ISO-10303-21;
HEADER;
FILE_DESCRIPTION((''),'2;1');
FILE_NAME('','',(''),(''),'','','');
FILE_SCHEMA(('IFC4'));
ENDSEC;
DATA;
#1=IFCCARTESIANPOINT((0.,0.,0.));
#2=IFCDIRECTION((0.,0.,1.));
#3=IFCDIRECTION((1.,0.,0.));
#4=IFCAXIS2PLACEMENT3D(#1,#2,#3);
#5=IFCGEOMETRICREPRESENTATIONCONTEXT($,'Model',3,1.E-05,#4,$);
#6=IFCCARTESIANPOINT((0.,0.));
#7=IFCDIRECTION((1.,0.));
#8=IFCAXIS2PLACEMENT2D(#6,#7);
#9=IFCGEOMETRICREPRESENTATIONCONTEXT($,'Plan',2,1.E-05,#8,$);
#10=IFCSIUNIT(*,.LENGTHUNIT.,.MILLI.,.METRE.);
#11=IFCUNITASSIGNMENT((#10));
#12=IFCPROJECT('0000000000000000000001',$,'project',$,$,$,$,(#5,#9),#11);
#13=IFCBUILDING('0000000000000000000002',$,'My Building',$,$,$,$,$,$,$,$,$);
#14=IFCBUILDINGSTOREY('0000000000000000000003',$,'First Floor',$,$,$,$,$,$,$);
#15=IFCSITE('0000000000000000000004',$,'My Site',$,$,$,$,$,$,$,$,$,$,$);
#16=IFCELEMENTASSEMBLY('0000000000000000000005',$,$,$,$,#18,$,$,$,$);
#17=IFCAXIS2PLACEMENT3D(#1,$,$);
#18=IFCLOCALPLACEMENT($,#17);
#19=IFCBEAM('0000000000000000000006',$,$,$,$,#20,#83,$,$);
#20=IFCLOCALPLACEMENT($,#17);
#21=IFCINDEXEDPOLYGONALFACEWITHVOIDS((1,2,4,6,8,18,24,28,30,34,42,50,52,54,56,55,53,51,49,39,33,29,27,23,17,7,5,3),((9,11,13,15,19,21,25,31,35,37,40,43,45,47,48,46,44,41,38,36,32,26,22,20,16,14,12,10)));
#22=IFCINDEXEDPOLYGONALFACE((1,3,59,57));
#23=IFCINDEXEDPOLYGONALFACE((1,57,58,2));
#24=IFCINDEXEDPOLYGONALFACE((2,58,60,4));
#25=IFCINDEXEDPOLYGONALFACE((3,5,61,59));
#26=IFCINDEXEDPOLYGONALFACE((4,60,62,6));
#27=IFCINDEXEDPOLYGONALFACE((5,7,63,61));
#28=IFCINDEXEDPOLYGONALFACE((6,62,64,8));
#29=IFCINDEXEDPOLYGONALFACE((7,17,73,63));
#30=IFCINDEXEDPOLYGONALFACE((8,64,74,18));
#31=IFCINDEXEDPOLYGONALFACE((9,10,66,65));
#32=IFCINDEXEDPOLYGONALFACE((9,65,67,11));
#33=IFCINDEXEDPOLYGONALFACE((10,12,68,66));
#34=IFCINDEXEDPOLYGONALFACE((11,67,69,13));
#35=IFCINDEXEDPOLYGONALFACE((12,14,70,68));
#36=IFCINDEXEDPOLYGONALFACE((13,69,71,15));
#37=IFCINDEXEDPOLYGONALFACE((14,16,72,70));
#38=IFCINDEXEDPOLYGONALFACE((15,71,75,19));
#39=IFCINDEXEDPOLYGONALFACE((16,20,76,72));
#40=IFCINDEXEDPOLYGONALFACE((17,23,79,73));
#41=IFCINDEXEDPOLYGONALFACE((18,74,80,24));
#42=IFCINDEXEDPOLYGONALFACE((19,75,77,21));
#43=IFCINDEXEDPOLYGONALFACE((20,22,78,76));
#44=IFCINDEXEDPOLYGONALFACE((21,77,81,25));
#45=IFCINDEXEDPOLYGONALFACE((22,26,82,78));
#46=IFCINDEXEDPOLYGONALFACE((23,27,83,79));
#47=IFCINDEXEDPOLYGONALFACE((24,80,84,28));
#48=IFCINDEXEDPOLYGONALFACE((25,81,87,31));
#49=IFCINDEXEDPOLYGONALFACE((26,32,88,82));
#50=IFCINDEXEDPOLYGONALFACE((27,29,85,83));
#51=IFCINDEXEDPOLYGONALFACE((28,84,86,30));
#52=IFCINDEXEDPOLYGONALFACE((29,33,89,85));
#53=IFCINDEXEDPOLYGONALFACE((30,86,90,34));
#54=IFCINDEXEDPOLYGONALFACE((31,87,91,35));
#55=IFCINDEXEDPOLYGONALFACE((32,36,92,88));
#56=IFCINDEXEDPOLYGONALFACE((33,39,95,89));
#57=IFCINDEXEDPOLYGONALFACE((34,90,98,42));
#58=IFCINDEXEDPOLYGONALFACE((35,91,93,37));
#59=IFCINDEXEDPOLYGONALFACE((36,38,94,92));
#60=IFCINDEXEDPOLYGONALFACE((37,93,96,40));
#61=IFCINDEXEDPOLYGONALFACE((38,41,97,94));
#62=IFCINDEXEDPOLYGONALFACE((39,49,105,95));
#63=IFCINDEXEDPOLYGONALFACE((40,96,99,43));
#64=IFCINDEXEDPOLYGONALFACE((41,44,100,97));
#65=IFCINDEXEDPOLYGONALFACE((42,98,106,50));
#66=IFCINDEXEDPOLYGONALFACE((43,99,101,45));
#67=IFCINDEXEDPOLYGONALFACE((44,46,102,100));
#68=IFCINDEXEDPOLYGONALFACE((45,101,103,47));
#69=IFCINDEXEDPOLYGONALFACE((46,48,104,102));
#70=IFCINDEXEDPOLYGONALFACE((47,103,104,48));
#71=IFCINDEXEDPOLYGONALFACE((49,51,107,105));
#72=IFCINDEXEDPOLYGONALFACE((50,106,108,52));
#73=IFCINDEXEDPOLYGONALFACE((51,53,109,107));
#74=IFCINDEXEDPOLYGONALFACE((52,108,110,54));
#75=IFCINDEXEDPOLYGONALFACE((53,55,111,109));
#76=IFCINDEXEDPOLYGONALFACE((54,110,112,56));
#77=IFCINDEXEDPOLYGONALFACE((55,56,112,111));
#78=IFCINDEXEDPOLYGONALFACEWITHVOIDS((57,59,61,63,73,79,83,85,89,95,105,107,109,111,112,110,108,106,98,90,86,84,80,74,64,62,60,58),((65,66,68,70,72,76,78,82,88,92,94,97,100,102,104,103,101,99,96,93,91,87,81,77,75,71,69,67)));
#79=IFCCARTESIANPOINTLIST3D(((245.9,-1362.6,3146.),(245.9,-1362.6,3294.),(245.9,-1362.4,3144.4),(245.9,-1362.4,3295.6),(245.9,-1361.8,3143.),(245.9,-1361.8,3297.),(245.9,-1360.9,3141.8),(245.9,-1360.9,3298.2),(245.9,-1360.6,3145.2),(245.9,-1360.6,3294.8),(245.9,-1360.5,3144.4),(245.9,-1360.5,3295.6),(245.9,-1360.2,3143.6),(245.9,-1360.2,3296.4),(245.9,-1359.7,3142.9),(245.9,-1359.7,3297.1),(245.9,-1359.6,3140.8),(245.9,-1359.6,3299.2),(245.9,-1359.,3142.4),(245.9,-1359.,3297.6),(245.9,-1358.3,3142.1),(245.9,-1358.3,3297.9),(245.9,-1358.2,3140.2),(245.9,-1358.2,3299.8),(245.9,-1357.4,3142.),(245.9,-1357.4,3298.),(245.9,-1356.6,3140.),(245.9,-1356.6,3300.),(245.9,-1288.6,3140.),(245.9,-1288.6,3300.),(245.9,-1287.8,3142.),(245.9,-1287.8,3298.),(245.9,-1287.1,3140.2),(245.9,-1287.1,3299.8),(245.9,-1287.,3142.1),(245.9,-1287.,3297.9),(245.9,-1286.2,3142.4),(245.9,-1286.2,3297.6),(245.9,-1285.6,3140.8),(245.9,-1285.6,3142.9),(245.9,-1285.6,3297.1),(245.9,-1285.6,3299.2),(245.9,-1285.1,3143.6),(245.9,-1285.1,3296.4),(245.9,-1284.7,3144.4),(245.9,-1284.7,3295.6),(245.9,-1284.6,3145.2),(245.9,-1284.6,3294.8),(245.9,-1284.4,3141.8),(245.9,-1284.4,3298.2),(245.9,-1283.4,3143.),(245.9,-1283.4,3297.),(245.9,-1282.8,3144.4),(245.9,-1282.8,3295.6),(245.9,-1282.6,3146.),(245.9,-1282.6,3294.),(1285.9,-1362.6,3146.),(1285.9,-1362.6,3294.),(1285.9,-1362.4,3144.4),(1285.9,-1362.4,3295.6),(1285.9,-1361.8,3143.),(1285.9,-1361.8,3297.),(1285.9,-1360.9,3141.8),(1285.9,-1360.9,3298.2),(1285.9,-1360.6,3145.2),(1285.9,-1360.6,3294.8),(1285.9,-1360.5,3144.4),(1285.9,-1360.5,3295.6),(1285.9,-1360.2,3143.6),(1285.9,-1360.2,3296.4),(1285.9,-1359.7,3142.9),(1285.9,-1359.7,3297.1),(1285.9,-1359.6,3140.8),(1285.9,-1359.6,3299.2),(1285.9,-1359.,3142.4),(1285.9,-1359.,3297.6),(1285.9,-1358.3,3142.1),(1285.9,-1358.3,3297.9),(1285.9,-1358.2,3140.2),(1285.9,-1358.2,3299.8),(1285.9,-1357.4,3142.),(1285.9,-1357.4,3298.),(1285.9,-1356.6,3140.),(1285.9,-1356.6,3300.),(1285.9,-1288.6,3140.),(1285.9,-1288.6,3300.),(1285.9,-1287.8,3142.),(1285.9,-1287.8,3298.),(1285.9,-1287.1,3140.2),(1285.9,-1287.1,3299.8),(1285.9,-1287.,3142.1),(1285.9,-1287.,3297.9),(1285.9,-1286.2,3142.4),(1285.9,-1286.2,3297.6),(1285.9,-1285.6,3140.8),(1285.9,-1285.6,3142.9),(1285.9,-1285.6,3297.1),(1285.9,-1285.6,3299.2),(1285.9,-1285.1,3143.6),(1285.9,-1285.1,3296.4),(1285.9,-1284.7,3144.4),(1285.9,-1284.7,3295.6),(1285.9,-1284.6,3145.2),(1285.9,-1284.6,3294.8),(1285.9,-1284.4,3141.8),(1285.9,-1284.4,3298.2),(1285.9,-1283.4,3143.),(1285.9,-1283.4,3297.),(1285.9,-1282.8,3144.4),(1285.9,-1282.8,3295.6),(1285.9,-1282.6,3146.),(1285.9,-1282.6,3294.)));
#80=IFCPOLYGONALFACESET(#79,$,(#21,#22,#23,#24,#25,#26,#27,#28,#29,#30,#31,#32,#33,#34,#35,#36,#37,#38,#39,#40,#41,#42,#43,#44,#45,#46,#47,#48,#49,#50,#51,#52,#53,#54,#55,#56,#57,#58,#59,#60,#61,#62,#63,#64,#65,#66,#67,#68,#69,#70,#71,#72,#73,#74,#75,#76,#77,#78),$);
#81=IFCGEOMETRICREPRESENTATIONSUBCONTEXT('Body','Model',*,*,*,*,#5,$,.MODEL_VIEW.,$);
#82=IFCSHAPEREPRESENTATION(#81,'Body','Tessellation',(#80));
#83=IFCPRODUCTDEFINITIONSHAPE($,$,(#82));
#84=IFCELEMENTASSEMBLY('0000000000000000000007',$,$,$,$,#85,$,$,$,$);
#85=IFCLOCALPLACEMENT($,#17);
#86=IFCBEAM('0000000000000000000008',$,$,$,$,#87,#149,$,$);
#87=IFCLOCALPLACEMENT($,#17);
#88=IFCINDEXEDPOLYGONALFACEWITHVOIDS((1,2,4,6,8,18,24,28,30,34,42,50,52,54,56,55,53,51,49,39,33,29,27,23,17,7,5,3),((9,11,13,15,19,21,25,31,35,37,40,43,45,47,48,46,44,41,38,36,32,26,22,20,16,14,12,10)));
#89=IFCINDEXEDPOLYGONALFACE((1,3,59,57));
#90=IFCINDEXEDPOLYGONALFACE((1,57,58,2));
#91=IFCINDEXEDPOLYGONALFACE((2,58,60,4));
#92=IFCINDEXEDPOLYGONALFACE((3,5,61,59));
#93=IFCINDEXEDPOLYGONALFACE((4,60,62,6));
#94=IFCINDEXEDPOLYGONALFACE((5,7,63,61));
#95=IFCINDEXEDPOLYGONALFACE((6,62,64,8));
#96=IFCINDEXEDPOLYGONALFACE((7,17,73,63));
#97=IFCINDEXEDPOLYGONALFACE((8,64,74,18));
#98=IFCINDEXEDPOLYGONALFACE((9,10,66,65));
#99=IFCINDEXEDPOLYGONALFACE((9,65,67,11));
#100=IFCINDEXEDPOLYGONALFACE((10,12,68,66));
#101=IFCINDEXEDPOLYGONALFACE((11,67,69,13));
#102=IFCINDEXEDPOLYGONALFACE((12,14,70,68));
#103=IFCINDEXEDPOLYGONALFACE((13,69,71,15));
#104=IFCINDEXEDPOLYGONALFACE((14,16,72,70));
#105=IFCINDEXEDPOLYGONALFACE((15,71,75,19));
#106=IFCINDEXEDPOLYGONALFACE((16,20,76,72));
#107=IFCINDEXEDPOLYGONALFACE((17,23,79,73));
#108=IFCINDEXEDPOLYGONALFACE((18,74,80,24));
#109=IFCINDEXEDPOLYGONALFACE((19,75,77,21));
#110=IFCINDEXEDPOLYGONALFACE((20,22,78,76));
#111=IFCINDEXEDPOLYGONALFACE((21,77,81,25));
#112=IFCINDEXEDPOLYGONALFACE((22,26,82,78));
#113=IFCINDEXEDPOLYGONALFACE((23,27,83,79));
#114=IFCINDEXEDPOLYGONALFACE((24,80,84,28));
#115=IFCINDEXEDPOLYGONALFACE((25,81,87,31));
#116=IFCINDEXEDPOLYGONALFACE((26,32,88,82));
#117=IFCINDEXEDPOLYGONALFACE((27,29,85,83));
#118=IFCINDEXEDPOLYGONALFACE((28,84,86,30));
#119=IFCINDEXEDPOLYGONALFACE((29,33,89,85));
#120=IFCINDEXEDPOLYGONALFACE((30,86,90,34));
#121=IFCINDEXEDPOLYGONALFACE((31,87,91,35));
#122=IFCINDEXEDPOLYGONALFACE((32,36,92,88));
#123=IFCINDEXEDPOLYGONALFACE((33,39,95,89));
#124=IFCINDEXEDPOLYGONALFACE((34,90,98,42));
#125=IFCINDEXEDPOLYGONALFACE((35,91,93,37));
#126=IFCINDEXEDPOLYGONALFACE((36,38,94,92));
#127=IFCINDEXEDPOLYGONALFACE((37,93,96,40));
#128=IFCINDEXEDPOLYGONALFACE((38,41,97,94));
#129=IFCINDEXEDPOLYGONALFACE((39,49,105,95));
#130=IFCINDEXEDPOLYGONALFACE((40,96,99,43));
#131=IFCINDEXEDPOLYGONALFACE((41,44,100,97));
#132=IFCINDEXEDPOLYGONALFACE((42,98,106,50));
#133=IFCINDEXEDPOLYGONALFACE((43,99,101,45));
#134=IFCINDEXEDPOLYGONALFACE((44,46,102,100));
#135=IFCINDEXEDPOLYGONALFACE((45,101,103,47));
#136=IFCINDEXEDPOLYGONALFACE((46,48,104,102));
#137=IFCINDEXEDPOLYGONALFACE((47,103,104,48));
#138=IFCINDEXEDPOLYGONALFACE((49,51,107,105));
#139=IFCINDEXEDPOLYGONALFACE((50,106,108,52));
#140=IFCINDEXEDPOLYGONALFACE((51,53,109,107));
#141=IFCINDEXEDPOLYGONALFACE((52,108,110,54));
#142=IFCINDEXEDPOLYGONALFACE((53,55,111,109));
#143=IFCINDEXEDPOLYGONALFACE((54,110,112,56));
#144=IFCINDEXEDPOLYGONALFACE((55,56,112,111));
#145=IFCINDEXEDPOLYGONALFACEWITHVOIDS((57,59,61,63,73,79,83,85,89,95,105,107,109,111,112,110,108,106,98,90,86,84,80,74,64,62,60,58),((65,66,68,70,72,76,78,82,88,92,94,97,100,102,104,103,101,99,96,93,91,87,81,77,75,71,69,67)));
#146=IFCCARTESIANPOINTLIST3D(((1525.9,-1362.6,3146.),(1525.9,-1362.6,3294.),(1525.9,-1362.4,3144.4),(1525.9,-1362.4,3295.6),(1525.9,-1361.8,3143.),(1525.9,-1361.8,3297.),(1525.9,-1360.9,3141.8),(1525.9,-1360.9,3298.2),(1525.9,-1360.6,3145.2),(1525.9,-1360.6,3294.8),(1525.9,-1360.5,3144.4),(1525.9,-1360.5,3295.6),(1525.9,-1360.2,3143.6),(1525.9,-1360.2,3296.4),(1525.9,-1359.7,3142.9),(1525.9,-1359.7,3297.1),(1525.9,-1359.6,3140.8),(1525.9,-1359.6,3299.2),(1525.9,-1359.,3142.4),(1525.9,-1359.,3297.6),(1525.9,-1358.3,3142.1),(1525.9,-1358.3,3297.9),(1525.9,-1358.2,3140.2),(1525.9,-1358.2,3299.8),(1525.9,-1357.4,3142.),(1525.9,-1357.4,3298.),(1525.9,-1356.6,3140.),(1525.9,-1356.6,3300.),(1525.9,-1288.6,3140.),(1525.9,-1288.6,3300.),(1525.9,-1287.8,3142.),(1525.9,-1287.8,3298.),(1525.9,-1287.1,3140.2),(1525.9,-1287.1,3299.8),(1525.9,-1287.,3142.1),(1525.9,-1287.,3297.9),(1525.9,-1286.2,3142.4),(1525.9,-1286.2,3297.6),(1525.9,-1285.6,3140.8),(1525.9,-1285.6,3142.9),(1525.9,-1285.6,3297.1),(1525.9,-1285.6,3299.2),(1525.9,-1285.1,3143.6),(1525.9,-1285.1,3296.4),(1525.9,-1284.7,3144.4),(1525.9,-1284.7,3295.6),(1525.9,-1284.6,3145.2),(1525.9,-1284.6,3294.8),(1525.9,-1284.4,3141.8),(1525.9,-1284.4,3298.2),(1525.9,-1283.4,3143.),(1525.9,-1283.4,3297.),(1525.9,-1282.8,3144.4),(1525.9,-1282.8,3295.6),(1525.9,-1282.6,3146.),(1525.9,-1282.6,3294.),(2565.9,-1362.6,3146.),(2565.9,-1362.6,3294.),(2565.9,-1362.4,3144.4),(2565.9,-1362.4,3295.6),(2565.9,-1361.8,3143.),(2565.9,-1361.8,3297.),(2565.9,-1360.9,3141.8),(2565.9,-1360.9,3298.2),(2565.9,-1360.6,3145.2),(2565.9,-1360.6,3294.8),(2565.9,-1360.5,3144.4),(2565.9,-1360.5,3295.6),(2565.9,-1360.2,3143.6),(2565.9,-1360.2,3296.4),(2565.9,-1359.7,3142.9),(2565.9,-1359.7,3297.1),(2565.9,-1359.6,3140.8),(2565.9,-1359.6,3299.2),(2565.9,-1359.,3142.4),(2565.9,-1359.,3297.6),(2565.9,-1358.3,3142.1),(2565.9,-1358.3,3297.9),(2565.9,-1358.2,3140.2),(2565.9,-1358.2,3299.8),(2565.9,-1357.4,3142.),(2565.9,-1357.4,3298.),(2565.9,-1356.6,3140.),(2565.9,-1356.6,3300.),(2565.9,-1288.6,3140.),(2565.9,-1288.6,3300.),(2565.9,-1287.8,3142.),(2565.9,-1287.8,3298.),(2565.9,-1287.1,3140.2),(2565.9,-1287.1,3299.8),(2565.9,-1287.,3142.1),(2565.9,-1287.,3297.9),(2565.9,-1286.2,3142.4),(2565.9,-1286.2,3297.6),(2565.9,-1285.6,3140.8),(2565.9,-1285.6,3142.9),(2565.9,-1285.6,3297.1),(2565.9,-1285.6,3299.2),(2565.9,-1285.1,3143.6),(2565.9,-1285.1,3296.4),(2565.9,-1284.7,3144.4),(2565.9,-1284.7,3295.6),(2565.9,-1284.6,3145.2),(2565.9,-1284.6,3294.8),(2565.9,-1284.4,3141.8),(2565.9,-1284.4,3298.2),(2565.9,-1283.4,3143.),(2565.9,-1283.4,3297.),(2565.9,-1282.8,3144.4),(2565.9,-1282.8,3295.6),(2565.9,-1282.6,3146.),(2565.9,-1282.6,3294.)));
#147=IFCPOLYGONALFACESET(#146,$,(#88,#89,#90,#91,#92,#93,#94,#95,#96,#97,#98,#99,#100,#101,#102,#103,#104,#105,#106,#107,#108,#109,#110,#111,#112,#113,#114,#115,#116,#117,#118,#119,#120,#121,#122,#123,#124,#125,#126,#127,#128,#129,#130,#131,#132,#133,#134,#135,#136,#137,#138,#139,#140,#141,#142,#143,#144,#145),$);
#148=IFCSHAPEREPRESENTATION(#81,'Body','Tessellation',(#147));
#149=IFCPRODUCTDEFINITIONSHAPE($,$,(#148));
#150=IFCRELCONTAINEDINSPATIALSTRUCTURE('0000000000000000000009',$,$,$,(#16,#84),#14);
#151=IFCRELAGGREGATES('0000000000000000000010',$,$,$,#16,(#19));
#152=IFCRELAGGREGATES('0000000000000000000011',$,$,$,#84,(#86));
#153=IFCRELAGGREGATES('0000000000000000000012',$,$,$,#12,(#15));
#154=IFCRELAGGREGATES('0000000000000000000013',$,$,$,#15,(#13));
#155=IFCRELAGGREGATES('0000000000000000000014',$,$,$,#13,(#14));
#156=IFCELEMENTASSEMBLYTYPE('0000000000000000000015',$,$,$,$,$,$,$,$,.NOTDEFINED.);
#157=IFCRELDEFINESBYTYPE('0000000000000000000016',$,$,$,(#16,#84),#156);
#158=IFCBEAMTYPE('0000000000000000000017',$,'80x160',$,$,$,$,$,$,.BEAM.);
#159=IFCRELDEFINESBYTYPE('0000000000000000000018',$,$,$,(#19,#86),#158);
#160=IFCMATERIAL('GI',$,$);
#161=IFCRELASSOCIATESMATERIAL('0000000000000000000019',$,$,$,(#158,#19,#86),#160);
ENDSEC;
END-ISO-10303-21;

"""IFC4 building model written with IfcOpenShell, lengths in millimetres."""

from ifc_helpers import new_model, si_unit, frame, origin_with_axes, origin_2d_with_axis, place, context, subcontext, project, spatial, hollow_rectangle, extrude, material, material_profile, profile_set, profile_usage, type_object, element, aggregate, save


model = new_model("IFC4")

# Units and contexts
model_context = context("Model", 3, precision=1e-05, world=origin_with_axes())
plan_context = context("Plan", 2, precision=1e-05, world=origin_2d_with_axis())
body_context = subcontext(model_context, "Body", "Model", "MODEL_VIEW")
ifc_project = project(units=[si_unit("LENGTHUNIT", "METRE", prefix="MILLI")], contexts=[model_context, plan_context])

# Site, building, storey
site = spatial("IfcSite", under=ifc_project, Name="My Site")
building = spatial("IfcBuilding", under=site, Name="My Building")
storey = spatial("IfcBuildingStorey", under=building, Name="First Floor")

# Element assemblies, beams
element_assembly_type = type_object("IfcElementAssemblyType", PredefinedType="NOTDEFINED")
assembly_1_placement = place(None, frame((165.9, -1322.6, 3220.0), z_axis=(1.0, 0.0, 0.0), x_axis=(0.0, 1.0, 0.0)))
assembly_1 = element("IfcElementAssembly", 1, at=assembly_1_placement, inside=storey, type_object=element_assembly_type)
ifc_material = material(Name="GI")
ifc_material_profile = material_profile(ifc_material, hollow_rectangle(XDim=80.0, YDim=160.0, WallThickness=2.0, InnerFilletRadius=3.2, OuterFilletRadius=6.0))
ifc_profile_set = profile_set([ifc_material_profile], Name="80x160 GI Rectangular Hollow")
ifc_profile_usage_1 = profile_usage(ifc_profile_set)
beam_type = type_object("IfcBeamType", Name="80x160", PredefinedType="BEAM", material=ifc_profile_set)
beam_1_placement = place(assembly_1_placement, frame((0.0, 0.0, 80.0), z_axis=(0.0, 0.0, 1.0), x_axis=(1.0, 0.0, 0.0)))
beam_1 = element("IfcBeam", 2, at=beam_1_placement, type_object=beam_type, material=ifc_profile_usage_1, context=body_context, shape_type="SweptSolid", body=[
    extrude(hollow_rectangle(XDim=80.0, YDim=160.0, WallThickness=2.0, InnerFilletRadius=3.2, OuterFilletRadius=6.0), origin_with_axes(), (0.0, 0.0, 1.0), 1040.0),
])
aggregate(assembly_1, [beam_1])
assembly_2_placement = place(None, frame((1445.9, -1322.6, 3220.0), z_axis=(1.0, 0.0, 0.0), x_axis=(0.0, 1.0, 0.0)))
assembly_2 = element("IfcElementAssembly", 3, at=assembly_2_placement, inside=storey, type_object=element_assembly_type)
ifc_profile_usage_2 = profile_usage(ifc_profile_set)
beam_2_placement = place(assembly_2_placement, frame((0.0, 0.0, 80.0), z_axis=(0.0, 0.0, 1.0), x_axis=(1.0, 0.0, 0.0)))
beam_2 = element("IfcBeam", 4, at=beam_2_placement, type_object=beam_type, material=ifc_profile_usage_2, context=body_context, shape_type="SweptSolid", body=[
    extrude(hollow_rectangle(XDim=80.0, YDim=160.0, WallThickness=2.0, InnerFilletRadius=3.2, OuterFilletRadius=6.0), origin_with_axes(), (0.0, 0.0, 1.0), 1040.0),
])
aggregate(assembly_2, [beam_2])

save(model, "model.ifc")
